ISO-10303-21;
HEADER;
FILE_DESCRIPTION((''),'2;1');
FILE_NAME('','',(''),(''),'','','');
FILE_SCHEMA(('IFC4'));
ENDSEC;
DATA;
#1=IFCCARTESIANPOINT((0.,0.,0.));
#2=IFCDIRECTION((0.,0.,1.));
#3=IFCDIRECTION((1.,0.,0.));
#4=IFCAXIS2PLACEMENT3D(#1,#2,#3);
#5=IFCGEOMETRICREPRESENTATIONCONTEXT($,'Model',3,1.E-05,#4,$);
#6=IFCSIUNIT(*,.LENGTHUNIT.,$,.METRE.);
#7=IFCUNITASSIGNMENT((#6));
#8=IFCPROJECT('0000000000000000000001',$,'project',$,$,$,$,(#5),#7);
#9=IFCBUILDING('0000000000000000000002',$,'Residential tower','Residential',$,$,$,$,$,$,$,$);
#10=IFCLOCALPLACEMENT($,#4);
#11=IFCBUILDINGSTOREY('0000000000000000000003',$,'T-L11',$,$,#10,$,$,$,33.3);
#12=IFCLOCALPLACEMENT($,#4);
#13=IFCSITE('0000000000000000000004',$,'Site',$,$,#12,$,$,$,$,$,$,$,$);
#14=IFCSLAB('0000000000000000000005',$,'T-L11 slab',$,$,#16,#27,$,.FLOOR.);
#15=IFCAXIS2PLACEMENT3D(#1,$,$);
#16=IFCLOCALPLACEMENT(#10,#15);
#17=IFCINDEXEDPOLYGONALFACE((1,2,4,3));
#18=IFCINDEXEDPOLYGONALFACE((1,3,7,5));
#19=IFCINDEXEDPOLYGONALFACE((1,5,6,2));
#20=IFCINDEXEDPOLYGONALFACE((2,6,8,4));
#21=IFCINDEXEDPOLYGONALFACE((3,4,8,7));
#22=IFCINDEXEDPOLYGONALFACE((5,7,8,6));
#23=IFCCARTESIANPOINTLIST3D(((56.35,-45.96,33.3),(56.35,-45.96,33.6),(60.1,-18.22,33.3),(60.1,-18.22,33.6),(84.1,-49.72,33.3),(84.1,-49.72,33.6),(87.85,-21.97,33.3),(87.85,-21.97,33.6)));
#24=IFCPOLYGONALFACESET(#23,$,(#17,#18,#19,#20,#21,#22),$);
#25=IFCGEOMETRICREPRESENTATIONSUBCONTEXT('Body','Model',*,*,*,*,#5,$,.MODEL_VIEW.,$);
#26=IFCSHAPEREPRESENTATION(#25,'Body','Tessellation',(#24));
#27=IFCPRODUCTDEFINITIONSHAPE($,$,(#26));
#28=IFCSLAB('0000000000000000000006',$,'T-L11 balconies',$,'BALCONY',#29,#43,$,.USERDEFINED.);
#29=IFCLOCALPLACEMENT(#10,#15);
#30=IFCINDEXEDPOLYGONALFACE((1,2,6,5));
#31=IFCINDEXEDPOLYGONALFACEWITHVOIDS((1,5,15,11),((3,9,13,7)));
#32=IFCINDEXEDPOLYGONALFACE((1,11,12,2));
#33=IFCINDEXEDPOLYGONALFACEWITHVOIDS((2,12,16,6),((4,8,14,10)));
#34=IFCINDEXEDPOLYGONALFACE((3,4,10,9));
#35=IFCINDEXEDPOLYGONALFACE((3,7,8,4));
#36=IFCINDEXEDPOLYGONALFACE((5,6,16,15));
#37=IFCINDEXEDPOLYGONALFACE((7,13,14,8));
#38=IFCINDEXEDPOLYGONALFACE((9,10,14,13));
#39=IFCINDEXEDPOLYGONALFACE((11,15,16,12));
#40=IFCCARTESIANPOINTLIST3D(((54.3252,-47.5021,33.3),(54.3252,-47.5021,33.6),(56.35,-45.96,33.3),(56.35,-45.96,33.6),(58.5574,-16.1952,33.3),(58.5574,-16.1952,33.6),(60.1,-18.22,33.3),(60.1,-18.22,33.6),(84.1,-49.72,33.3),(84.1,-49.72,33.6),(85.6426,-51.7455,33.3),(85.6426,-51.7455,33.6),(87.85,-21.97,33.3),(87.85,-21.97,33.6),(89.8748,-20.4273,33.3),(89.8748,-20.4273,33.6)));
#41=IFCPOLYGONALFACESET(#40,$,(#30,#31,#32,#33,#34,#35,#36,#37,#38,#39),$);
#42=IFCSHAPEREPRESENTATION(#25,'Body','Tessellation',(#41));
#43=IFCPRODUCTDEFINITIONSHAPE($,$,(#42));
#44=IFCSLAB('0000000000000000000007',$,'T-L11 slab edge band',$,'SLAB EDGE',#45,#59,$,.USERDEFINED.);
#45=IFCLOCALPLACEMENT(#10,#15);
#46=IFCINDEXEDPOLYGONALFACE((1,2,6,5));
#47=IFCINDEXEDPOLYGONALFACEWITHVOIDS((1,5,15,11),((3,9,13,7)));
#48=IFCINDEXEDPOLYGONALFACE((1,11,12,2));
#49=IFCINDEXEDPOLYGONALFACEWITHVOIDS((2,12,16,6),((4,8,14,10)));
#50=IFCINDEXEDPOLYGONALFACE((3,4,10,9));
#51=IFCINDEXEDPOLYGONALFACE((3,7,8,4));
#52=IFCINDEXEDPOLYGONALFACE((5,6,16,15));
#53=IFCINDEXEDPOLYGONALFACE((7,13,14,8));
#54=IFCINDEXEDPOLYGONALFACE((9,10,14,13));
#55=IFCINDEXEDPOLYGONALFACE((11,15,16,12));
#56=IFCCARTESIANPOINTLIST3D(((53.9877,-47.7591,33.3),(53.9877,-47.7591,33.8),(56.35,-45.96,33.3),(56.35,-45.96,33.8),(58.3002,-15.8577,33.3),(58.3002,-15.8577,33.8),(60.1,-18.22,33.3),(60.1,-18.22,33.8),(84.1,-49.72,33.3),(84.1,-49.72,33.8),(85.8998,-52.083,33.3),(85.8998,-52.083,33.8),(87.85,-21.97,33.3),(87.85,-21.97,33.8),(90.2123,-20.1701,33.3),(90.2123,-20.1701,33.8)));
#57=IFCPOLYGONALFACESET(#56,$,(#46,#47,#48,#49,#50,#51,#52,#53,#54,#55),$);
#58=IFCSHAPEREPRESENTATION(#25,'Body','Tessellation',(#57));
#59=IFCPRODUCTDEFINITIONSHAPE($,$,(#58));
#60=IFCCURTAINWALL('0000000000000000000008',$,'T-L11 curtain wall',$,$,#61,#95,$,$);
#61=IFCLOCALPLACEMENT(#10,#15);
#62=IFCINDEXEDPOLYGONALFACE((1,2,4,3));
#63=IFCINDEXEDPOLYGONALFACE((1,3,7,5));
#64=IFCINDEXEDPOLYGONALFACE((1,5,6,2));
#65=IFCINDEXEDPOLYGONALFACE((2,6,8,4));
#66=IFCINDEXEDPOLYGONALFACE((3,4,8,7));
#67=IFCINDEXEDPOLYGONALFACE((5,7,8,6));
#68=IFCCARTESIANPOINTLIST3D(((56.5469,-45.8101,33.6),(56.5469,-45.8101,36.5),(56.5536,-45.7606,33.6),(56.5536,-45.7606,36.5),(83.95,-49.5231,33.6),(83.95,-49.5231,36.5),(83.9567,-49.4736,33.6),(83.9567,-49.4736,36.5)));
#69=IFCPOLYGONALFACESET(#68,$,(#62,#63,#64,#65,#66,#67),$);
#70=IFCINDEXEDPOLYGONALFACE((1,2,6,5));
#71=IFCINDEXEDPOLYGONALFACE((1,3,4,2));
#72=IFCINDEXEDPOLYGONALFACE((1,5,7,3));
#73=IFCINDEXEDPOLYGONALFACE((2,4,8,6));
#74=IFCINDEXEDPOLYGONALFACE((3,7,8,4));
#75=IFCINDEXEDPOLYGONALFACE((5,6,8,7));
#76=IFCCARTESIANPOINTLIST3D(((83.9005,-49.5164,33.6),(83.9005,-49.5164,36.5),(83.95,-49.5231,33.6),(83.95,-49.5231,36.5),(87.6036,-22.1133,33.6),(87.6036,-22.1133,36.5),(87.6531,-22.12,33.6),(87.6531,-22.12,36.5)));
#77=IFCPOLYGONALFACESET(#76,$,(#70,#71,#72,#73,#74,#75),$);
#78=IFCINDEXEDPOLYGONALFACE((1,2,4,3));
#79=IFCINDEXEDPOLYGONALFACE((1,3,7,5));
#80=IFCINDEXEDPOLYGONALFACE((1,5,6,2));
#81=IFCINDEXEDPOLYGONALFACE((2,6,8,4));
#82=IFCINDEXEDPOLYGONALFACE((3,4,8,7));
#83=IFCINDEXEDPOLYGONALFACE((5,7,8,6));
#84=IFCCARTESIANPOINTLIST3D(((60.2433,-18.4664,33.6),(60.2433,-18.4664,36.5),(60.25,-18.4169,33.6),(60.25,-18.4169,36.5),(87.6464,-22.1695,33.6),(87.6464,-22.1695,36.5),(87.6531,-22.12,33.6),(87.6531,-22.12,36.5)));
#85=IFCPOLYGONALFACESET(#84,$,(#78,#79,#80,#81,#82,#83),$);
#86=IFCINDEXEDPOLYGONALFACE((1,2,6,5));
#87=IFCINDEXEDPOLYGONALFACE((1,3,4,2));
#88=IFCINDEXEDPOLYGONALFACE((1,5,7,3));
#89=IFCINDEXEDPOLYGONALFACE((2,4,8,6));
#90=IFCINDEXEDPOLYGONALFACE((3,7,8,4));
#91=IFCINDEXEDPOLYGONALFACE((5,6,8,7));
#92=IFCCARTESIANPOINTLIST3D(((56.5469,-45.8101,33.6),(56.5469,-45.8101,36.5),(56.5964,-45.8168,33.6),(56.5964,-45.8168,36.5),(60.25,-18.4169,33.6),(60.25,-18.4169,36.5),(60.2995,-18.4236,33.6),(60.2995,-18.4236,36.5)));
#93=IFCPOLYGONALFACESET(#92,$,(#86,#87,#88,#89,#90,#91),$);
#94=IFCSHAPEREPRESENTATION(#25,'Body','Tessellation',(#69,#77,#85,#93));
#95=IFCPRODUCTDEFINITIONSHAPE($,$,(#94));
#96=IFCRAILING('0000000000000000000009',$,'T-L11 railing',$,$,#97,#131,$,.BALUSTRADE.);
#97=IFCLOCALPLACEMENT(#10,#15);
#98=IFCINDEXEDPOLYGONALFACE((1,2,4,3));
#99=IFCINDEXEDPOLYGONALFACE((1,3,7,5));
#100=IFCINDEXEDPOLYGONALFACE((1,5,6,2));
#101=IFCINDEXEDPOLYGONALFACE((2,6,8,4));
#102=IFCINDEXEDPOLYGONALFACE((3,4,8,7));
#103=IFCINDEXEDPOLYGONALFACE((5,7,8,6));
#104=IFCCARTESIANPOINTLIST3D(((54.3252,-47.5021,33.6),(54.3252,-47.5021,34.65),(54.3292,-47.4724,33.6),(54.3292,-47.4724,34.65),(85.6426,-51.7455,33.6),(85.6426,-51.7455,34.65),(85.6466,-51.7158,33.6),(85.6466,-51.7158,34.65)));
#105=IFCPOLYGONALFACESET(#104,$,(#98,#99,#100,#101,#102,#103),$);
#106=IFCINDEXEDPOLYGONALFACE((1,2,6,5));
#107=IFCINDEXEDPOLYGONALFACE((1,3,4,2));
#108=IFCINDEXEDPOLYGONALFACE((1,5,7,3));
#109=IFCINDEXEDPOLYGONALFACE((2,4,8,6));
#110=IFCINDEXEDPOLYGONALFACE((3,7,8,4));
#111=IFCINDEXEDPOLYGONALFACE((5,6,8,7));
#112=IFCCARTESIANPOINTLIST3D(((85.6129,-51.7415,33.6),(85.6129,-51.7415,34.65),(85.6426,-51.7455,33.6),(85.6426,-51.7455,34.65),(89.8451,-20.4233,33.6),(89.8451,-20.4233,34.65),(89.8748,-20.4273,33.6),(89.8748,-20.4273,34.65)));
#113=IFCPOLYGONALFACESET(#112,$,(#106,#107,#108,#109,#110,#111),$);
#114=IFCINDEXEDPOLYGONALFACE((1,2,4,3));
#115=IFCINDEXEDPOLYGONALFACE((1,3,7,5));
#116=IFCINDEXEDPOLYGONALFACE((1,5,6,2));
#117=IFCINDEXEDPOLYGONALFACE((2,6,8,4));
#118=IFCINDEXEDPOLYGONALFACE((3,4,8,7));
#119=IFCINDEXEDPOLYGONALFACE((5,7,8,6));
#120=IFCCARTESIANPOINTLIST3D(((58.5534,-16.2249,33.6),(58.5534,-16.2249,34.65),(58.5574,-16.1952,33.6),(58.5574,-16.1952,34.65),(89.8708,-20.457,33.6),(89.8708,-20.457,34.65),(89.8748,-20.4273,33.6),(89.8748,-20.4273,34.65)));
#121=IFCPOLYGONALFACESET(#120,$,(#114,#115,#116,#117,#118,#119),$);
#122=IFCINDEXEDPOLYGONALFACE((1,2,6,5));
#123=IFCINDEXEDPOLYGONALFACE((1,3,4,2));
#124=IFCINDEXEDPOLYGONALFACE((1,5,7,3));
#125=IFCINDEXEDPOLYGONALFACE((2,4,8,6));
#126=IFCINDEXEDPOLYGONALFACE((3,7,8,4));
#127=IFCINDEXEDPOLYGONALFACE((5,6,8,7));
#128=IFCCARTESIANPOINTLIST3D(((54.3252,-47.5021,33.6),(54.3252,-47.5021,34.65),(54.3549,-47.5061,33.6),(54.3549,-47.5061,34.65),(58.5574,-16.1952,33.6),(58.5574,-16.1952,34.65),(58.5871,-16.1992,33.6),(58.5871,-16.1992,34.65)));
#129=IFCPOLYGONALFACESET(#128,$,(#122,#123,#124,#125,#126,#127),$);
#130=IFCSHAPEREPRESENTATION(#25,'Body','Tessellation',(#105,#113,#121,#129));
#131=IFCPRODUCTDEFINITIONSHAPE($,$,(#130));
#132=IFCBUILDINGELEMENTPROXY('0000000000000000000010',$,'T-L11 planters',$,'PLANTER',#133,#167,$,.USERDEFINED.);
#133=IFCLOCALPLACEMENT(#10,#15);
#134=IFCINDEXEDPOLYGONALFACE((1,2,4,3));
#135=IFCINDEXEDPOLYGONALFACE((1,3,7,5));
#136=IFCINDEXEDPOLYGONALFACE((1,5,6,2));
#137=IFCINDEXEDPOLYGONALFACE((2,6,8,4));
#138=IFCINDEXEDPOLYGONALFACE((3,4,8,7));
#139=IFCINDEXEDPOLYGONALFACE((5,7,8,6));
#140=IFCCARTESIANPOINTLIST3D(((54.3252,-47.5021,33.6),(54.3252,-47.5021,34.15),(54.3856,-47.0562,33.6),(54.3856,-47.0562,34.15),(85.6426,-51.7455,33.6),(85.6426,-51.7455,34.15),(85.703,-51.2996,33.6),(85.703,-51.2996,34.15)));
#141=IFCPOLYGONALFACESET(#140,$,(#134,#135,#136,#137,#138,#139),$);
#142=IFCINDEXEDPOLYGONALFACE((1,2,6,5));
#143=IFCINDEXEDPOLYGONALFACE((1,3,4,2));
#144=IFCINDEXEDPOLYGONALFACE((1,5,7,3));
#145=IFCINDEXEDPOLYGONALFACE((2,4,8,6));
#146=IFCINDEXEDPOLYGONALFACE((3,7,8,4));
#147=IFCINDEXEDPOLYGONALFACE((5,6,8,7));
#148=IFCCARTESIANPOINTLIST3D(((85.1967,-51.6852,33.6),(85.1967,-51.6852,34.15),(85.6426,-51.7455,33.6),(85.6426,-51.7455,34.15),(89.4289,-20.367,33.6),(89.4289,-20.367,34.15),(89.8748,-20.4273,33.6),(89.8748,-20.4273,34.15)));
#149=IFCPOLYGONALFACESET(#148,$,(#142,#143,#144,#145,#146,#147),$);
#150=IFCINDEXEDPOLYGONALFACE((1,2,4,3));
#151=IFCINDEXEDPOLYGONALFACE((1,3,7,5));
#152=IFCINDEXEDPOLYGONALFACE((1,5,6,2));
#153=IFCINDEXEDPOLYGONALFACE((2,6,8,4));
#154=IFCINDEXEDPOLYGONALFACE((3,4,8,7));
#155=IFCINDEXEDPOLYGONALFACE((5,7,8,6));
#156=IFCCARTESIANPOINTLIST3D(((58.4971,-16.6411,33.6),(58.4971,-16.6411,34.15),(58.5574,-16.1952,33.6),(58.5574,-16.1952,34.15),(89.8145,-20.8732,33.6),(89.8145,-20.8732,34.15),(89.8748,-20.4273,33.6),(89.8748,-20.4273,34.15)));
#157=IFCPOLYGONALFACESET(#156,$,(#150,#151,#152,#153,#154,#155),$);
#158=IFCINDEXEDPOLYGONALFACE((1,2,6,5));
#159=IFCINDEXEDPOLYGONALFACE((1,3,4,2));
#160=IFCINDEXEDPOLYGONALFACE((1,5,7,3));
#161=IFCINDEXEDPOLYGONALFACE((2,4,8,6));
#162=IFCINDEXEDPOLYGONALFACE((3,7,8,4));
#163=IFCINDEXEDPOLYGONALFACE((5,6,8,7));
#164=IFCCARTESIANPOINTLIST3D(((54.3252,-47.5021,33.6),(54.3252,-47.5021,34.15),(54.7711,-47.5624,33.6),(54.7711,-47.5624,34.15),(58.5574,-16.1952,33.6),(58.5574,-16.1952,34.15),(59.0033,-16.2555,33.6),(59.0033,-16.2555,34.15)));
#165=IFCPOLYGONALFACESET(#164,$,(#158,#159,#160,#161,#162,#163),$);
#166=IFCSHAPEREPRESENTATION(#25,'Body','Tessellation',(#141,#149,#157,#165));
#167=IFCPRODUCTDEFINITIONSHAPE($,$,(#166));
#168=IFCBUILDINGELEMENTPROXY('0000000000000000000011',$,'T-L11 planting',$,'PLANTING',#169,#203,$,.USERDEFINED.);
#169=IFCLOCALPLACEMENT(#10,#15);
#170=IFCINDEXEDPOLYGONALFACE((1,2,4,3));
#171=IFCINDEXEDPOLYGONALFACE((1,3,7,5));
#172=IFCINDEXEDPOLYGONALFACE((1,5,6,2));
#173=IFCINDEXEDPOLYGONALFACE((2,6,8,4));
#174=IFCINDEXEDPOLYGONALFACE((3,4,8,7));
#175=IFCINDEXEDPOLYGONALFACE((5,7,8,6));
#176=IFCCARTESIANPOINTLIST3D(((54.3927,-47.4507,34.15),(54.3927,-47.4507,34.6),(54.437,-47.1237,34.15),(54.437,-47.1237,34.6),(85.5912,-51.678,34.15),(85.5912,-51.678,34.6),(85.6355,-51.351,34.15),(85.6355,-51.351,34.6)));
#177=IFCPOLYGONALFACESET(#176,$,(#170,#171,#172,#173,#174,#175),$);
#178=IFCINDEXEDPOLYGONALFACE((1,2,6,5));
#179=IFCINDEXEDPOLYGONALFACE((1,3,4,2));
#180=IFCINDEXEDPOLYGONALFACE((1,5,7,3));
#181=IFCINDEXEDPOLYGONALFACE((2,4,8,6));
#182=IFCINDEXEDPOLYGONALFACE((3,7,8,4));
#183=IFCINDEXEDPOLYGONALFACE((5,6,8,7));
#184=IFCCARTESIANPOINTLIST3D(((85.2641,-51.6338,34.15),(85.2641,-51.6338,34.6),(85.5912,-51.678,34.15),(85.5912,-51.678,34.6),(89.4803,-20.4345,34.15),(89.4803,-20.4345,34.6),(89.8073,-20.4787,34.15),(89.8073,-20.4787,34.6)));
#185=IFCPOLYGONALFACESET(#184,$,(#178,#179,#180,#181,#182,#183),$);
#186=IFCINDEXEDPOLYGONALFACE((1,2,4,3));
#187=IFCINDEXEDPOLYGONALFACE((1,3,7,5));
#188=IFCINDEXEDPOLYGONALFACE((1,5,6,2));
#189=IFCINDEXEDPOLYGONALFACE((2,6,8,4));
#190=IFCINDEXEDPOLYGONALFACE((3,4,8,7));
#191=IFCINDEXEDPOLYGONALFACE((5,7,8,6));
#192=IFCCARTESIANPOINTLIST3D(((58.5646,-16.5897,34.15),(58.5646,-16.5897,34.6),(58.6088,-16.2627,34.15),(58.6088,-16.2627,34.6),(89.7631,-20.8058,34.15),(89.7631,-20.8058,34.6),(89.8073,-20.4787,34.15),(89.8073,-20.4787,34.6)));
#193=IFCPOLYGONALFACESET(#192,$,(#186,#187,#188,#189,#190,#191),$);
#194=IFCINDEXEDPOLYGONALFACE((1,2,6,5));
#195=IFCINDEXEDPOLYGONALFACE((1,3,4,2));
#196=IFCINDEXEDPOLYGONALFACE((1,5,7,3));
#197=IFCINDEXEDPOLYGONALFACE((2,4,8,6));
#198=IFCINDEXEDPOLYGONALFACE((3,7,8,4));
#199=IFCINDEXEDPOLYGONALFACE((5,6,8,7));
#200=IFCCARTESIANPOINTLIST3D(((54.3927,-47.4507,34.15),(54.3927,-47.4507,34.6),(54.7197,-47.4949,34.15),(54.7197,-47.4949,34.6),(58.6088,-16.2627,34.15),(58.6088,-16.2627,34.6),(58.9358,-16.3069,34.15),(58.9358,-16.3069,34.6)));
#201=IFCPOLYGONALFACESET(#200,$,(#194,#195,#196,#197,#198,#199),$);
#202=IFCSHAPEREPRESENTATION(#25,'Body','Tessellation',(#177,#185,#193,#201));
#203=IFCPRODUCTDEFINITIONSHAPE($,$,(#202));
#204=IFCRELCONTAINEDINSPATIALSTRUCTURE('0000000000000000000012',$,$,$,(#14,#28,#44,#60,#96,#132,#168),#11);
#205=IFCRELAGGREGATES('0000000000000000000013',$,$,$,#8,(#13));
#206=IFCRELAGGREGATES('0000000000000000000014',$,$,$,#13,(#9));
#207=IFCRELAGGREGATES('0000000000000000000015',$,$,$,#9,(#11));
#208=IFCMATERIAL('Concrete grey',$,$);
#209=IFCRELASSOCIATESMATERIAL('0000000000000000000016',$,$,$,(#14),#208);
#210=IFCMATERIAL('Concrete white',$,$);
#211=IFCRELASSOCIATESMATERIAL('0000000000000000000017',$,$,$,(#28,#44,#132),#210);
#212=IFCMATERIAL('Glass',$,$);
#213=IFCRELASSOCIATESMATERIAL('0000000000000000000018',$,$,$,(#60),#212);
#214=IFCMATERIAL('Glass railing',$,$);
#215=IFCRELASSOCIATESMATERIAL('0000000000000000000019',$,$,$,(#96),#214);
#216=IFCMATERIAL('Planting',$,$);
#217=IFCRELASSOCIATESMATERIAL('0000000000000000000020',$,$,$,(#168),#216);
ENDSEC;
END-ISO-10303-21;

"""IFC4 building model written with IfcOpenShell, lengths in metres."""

from ifc_helpers import new_model, si_unit, frame, origin_with_axes, place, context, subcontext, project, spatial, polyline, outline, extrude, material, element, save


model = new_model("IFC4")

# Units and contexts
model_context = context("Model", 3, precision=1e-05, world=origin_with_axes())
body_context = subcontext(model_context, "Body", "Model", "MODEL_VIEW")
ifc_project = project(units=[si_unit("LENGTHUNIT", "METRE")], contexts=[model_context])

# Site, building, storey
site_placement = place(None, origin_with_axes())
site = spatial("IfcSite", under=ifc_project, at=site_placement, Name="Site")
building = spatial("IfcBuilding", under=site, Name="Residential tower", Description="Residential")
storey_placement = place(None, origin_with_axes())
storey = spatial("IfcBuildingStorey", under=building, at=storey_placement, Name="T-L11", Elevation=33.3)

# Slabs
ifc_material_1 = material(Name="Concrete grey")
slab_1_placement = place(storey_placement, origin_with_axes())
element("IfcSlab", 1, at=slab_1_placement, inside=storey, material=ifc_material_1, Name="T-L11 slab", PredefinedType="FLOOR", context=body_context, shape_type="SweptSolid", body=[
    extrude(outline(polyline([(56.35, -45.96), (84.1, -49.72), (87.85, -21.97), (60.1, -18.22), (56.35, -45.96)])), frame((0.0, 0.0, 33.3), z_axis=(0.0, 0.0, 1.0), x_axis=(1.0, 0.0, 0.0)), (0.0, 0.0, 1.0), 0.3),
])
ifc_material_2 = material(Name="Concrete white")
slab_2_placement = place(storey_placement, origin_with_axes())
element("IfcSlab", 2, at=slab_2_placement, inside=storey, material=ifc_material_2, Name="T-L11 balconies", ObjectType="BALCONY", PredefinedType="USERDEFINED", context=body_context, shape_type="SweptSolid", body=[
    extrude(outline(polyline([(54.3252, -47.5021), (85.6426, -51.7455), (89.8748, -20.4273), (58.5574, -16.1952), (54.3252, -47.5021)]), holes=[polyline([(56.35, -45.96), (84.1, -49.72), (87.85, -21.97), (60.1, -18.22), (56.35, -45.96)])]), frame((0.0, 0.0, 33.3), z_axis=(0.0, 0.0, 1.0), x_axis=(1.0, 0.0, 0.0)), (0.0, 0.0, 1.0), 0.3),
])
slab_3_placement = place(storey_placement, origin_with_axes())
element("IfcSlab", 3, at=slab_3_placement, inside=storey, material=ifc_material_2, Name="T-L11 slab edge band", ObjectType="SLAB EDGE", PredefinedType="USERDEFINED", context=body_context, shape_type="SweptSolid", body=[
    extrude(outline(polyline([(53.9877, -47.7591), (85.8998, -52.083), (90.2123, -20.1701), (58.3002, -15.8577), (53.9877, -47.7591)]), holes=[polyline([(56.35, -45.96), (84.1, -49.72), (87.85, -21.97), (60.1, -18.22), (56.35, -45.96)])]), frame((0.0, 0.0, 33.3), z_axis=(0.0, 0.0, 1.0), x_axis=(1.0, 0.0, 0.0)), (0.0, 0.0, 1.0), 0.5),
])

# Curtain wall
ifc_material_3 = material(Name="Glass")
curtain_wall_placement = place(storey_placement, origin_with_axes())
element("IfcCurtainWall", 4, at=curtain_wall_placement, inside=storey, material=ifc_material_3, Name="T-L11 curtain wall", context=body_context, shape_type="SweptSolid", body=[
    extrude(outline(polyline([(56.5469, -45.8101), (83.95, -49.5231), (83.9567, -49.4736), (56.5536, -45.7606), (56.5469, -45.8101)])), frame((0.0, 0.0, 33.6), z_axis=(0.0, 0.0, 1.0), x_axis=(1.0, 0.0, 0.0)), (0.0, 0.0, 1.0), 2.9),
    extrude(outline(polyline([(83.95, -49.5231), (87.6531, -22.12), (87.6036, -22.1133), (83.9005, -49.5164), (83.95, -49.5231)])), frame((0.0, 0.0, 33.6), z_axis=(0.0, 0.0, 1.0), x_axis=(1.0, 0.0, 0.0)), (0.0, 0.0, 1.0), 2.9),
    extrude(outline(polyline([(87.6531, -22.12), (60.25, -18.4169), (60.2433, -18.4664), (87.6464, -22.1695), (87.6531, -22.12)])), frame((0.0, 0.0, 33.6), z_axis=(0.0, 0.0, 1.0), x_axis=(1.0, 0.0, 0.0)), (0.0, 0.0, 1.0), 2.9),
    extrude(outline(polyline([(60.25, -18.4169), (56.5469, -45.8101), (56.5964, -45.8168), (60.2995, -18.4236), (60.25, -18.4169)])), frame((0.0, 0.0, 33.6), z_axis=(0.0, 0.0, 1.0), x_axis=(1.0, 0.0, 0.0)), (0.0, 0.0, 1.0), 2.9),
])

# Railing
ifc_material_4 = material(Name="Glass railing")
railing_placement = place(storey_placement, origin_with_axes())
element("IfcRailing", 5, at=railing_placement, inside=storey, material=ifc_material_4, Name="T-L11 railing", PredefinedType="BALUSTRADE", context=body_context, shape_type="SweptSolid", body=[
    extrude(outline(polyline([(54.3252, -47.5021), (85.6426, -51.7455), (85.6466, -51.7158), (54.3292, -47.4724), (54.3252, -47.5021)])), frame((0.0, 0.0, 33.6), z_axis=(0.0, 0.0, 1.0), x_axis=(1.0, 0.0, 0.0)), (0.0, 0.0, 1.0), 1.05),
    extrude(outline(polyline([(85.6426, -51.7455), (89.8748, -20.4273), (89.8451, -20.4233), (85.6129, -51.7415), (85.6426, -51.7455)])), frame((0.0, 0.0, 33.6), z_axis=(0.0, 0.0, 1.0), x_axis=(1.0, 0.0, 0.0)), (0.0, 0.0, 1.0), 1.05),
    extrude(outline(polyline([(89.8748, -20.4273), (58.5574, -16.1952), (58.5534, -16.2249), (89.8708, -20.457), (89.8748, -20.4273)])), frame((0.0, 0.0, 33.6), z_axis=(0.0, 0.0, 1.0), x_axis=(1.0, 0.0, 0.0)), (0.0, 0.0, 1.0), 1.05),
    extrude(outline(polyline([(58.5574, -16.1952), (54.3252, -47.5021), (54.3549, -47.5061), (58.5871, -16.1992), (58.5574, -16.1952)])), frame((0.0, 0.0, 33.6), z_axis=(0.0, 0.0, 1.0), x_axis=(1.0, 0.0, 0.0)), (0.0, 0.0, 1.0), 1.05),
])

# Building element proxies
proxy_1_placement = place(storey_placement, origin_with_axes())
element("IfcBuildingElementProxy", 6, at=proxy_1_placement, inside=storey, material=ifc_material_2, Name="T-L11 planters", ObjectType="PLANTER", PredefinedType="USERDEFINED", context=body_context, shape_type="SweptSolid", body=[
    extrude(outline(polyline([(54.3252, -47.5021), (85.6426, -51.7455), (85.703, -51.2996), (54.3856, -47.0562), (54.3252, -47.5021)])), frame((0.0, 0.0, 33.6), z_axis=(0.0, 0.0, 1.0), x_axis=(1.0, 0.0, 0.0)), (0.0, 0.0, 1.0), 0.55),
    extrude(outline(polyline([(85.6426, -51.7455), (89.8748, -20.4273), (89.4289, -20.367), (85.1967, -51.6852), (85.6426, -51.7455)])), frame((0.0, 0.0, 33.6), z_axis=(0.0, 0.0, 1.0), x_axis=(1.0, 0.0, 0.0)), (0.0, 0.0, 1.0), 0.55),
    extrude(outline(polyline([(89.8748, -20.4273), (58.5574, -16.1952), (58.4971, -16.6411), (89.8145, -20.8732), (89.8748, -20.4273)])), frame((0.0, 0.0, 33.6), z_axis=(0.0, 0.0, 1.0), x_axis=(1.0, 0.0, 0.0)), (0.0, 0.0, 1.0), 0.55),
    extrude(outline(polyline([(58.5574, -16.1952), (54.3252, -47.5021), (54.7711, -47.5624), (59.0033, -16.2555), (58.5574, -16.1952)])), frame((0.0, 0.0, 33.6), z_axis=(0.0, 0.0, 1.0), x_axis=(1.0, 0.0, 0.0)), (0.0, 0.0, 1.0), 0.55),
])
ifc_material_5 = material(Name="Planting")
proxy_2_placement = place(storey_placement, origin_with_axes())
element("IfcBuildingElementProxy", 7, at=proxy_2_placement, inside=storey, material=ifc_material_5, Name="T-L11 planting", ObjectType="PLANTING", PredefinedType="USERDEFINED", context=body_context, shape_type="SweptSolid", body=[
    extrude(outline(polyline([(54.3927, -47.4507), (85.5912, -51.678), (85.6355, -51.351), (54.437, -47.1237), (54.3927, -47.4507)])), frame((0.0, 0.0, 34.15), z_axis=(0.0, 0.0, 1.0), x_axis=(1.0, 0.0, 0.0)), (0.0, 0.0, 1.0), 0.45),
    extrude(outline(polyline([(85.5912, -51.678), (89.8073, -20.4787), (89.4803, -20.4345), (85.2641, -51.6338), (85.5912, -51.678)])), frame((0.0, 0.0, 34.15), z_axis=(0.0, 0.0, 1.0), x_axis=(1.0, 0.0, 0.0)), (0.0, 0.0, 1.0), 0.45),
    extrude(outline(polyline([(89.8073, -20.4787), (58.6088, -16.2627), (58.5646, -16.5897), (89.7631, -20.8058), (89.8073, -20.4787)])), frame((0.0, 0.0, 34.15), z_axis=(0.0, 0.0, 1.0), x_axis=(1.0, 0.0, 0.0)), (0.0, 0.0, 1.0), 0.45),
    extrude(outline(polyline([(58.6088, -16.2627), (54.3927, -47.4507), (54.7197, -47.4949), (58.9358, -16.3069), (58.6088, -16.2627)])), frame((0.0, 0.0, 34.15), z_axis=(0.0, 0.0, 1.0), x_axis=(1.0, 0.0, 0.0)), (0.0, 0.0, 1.0), 0.45),
])

save(model, "model.ifc")
